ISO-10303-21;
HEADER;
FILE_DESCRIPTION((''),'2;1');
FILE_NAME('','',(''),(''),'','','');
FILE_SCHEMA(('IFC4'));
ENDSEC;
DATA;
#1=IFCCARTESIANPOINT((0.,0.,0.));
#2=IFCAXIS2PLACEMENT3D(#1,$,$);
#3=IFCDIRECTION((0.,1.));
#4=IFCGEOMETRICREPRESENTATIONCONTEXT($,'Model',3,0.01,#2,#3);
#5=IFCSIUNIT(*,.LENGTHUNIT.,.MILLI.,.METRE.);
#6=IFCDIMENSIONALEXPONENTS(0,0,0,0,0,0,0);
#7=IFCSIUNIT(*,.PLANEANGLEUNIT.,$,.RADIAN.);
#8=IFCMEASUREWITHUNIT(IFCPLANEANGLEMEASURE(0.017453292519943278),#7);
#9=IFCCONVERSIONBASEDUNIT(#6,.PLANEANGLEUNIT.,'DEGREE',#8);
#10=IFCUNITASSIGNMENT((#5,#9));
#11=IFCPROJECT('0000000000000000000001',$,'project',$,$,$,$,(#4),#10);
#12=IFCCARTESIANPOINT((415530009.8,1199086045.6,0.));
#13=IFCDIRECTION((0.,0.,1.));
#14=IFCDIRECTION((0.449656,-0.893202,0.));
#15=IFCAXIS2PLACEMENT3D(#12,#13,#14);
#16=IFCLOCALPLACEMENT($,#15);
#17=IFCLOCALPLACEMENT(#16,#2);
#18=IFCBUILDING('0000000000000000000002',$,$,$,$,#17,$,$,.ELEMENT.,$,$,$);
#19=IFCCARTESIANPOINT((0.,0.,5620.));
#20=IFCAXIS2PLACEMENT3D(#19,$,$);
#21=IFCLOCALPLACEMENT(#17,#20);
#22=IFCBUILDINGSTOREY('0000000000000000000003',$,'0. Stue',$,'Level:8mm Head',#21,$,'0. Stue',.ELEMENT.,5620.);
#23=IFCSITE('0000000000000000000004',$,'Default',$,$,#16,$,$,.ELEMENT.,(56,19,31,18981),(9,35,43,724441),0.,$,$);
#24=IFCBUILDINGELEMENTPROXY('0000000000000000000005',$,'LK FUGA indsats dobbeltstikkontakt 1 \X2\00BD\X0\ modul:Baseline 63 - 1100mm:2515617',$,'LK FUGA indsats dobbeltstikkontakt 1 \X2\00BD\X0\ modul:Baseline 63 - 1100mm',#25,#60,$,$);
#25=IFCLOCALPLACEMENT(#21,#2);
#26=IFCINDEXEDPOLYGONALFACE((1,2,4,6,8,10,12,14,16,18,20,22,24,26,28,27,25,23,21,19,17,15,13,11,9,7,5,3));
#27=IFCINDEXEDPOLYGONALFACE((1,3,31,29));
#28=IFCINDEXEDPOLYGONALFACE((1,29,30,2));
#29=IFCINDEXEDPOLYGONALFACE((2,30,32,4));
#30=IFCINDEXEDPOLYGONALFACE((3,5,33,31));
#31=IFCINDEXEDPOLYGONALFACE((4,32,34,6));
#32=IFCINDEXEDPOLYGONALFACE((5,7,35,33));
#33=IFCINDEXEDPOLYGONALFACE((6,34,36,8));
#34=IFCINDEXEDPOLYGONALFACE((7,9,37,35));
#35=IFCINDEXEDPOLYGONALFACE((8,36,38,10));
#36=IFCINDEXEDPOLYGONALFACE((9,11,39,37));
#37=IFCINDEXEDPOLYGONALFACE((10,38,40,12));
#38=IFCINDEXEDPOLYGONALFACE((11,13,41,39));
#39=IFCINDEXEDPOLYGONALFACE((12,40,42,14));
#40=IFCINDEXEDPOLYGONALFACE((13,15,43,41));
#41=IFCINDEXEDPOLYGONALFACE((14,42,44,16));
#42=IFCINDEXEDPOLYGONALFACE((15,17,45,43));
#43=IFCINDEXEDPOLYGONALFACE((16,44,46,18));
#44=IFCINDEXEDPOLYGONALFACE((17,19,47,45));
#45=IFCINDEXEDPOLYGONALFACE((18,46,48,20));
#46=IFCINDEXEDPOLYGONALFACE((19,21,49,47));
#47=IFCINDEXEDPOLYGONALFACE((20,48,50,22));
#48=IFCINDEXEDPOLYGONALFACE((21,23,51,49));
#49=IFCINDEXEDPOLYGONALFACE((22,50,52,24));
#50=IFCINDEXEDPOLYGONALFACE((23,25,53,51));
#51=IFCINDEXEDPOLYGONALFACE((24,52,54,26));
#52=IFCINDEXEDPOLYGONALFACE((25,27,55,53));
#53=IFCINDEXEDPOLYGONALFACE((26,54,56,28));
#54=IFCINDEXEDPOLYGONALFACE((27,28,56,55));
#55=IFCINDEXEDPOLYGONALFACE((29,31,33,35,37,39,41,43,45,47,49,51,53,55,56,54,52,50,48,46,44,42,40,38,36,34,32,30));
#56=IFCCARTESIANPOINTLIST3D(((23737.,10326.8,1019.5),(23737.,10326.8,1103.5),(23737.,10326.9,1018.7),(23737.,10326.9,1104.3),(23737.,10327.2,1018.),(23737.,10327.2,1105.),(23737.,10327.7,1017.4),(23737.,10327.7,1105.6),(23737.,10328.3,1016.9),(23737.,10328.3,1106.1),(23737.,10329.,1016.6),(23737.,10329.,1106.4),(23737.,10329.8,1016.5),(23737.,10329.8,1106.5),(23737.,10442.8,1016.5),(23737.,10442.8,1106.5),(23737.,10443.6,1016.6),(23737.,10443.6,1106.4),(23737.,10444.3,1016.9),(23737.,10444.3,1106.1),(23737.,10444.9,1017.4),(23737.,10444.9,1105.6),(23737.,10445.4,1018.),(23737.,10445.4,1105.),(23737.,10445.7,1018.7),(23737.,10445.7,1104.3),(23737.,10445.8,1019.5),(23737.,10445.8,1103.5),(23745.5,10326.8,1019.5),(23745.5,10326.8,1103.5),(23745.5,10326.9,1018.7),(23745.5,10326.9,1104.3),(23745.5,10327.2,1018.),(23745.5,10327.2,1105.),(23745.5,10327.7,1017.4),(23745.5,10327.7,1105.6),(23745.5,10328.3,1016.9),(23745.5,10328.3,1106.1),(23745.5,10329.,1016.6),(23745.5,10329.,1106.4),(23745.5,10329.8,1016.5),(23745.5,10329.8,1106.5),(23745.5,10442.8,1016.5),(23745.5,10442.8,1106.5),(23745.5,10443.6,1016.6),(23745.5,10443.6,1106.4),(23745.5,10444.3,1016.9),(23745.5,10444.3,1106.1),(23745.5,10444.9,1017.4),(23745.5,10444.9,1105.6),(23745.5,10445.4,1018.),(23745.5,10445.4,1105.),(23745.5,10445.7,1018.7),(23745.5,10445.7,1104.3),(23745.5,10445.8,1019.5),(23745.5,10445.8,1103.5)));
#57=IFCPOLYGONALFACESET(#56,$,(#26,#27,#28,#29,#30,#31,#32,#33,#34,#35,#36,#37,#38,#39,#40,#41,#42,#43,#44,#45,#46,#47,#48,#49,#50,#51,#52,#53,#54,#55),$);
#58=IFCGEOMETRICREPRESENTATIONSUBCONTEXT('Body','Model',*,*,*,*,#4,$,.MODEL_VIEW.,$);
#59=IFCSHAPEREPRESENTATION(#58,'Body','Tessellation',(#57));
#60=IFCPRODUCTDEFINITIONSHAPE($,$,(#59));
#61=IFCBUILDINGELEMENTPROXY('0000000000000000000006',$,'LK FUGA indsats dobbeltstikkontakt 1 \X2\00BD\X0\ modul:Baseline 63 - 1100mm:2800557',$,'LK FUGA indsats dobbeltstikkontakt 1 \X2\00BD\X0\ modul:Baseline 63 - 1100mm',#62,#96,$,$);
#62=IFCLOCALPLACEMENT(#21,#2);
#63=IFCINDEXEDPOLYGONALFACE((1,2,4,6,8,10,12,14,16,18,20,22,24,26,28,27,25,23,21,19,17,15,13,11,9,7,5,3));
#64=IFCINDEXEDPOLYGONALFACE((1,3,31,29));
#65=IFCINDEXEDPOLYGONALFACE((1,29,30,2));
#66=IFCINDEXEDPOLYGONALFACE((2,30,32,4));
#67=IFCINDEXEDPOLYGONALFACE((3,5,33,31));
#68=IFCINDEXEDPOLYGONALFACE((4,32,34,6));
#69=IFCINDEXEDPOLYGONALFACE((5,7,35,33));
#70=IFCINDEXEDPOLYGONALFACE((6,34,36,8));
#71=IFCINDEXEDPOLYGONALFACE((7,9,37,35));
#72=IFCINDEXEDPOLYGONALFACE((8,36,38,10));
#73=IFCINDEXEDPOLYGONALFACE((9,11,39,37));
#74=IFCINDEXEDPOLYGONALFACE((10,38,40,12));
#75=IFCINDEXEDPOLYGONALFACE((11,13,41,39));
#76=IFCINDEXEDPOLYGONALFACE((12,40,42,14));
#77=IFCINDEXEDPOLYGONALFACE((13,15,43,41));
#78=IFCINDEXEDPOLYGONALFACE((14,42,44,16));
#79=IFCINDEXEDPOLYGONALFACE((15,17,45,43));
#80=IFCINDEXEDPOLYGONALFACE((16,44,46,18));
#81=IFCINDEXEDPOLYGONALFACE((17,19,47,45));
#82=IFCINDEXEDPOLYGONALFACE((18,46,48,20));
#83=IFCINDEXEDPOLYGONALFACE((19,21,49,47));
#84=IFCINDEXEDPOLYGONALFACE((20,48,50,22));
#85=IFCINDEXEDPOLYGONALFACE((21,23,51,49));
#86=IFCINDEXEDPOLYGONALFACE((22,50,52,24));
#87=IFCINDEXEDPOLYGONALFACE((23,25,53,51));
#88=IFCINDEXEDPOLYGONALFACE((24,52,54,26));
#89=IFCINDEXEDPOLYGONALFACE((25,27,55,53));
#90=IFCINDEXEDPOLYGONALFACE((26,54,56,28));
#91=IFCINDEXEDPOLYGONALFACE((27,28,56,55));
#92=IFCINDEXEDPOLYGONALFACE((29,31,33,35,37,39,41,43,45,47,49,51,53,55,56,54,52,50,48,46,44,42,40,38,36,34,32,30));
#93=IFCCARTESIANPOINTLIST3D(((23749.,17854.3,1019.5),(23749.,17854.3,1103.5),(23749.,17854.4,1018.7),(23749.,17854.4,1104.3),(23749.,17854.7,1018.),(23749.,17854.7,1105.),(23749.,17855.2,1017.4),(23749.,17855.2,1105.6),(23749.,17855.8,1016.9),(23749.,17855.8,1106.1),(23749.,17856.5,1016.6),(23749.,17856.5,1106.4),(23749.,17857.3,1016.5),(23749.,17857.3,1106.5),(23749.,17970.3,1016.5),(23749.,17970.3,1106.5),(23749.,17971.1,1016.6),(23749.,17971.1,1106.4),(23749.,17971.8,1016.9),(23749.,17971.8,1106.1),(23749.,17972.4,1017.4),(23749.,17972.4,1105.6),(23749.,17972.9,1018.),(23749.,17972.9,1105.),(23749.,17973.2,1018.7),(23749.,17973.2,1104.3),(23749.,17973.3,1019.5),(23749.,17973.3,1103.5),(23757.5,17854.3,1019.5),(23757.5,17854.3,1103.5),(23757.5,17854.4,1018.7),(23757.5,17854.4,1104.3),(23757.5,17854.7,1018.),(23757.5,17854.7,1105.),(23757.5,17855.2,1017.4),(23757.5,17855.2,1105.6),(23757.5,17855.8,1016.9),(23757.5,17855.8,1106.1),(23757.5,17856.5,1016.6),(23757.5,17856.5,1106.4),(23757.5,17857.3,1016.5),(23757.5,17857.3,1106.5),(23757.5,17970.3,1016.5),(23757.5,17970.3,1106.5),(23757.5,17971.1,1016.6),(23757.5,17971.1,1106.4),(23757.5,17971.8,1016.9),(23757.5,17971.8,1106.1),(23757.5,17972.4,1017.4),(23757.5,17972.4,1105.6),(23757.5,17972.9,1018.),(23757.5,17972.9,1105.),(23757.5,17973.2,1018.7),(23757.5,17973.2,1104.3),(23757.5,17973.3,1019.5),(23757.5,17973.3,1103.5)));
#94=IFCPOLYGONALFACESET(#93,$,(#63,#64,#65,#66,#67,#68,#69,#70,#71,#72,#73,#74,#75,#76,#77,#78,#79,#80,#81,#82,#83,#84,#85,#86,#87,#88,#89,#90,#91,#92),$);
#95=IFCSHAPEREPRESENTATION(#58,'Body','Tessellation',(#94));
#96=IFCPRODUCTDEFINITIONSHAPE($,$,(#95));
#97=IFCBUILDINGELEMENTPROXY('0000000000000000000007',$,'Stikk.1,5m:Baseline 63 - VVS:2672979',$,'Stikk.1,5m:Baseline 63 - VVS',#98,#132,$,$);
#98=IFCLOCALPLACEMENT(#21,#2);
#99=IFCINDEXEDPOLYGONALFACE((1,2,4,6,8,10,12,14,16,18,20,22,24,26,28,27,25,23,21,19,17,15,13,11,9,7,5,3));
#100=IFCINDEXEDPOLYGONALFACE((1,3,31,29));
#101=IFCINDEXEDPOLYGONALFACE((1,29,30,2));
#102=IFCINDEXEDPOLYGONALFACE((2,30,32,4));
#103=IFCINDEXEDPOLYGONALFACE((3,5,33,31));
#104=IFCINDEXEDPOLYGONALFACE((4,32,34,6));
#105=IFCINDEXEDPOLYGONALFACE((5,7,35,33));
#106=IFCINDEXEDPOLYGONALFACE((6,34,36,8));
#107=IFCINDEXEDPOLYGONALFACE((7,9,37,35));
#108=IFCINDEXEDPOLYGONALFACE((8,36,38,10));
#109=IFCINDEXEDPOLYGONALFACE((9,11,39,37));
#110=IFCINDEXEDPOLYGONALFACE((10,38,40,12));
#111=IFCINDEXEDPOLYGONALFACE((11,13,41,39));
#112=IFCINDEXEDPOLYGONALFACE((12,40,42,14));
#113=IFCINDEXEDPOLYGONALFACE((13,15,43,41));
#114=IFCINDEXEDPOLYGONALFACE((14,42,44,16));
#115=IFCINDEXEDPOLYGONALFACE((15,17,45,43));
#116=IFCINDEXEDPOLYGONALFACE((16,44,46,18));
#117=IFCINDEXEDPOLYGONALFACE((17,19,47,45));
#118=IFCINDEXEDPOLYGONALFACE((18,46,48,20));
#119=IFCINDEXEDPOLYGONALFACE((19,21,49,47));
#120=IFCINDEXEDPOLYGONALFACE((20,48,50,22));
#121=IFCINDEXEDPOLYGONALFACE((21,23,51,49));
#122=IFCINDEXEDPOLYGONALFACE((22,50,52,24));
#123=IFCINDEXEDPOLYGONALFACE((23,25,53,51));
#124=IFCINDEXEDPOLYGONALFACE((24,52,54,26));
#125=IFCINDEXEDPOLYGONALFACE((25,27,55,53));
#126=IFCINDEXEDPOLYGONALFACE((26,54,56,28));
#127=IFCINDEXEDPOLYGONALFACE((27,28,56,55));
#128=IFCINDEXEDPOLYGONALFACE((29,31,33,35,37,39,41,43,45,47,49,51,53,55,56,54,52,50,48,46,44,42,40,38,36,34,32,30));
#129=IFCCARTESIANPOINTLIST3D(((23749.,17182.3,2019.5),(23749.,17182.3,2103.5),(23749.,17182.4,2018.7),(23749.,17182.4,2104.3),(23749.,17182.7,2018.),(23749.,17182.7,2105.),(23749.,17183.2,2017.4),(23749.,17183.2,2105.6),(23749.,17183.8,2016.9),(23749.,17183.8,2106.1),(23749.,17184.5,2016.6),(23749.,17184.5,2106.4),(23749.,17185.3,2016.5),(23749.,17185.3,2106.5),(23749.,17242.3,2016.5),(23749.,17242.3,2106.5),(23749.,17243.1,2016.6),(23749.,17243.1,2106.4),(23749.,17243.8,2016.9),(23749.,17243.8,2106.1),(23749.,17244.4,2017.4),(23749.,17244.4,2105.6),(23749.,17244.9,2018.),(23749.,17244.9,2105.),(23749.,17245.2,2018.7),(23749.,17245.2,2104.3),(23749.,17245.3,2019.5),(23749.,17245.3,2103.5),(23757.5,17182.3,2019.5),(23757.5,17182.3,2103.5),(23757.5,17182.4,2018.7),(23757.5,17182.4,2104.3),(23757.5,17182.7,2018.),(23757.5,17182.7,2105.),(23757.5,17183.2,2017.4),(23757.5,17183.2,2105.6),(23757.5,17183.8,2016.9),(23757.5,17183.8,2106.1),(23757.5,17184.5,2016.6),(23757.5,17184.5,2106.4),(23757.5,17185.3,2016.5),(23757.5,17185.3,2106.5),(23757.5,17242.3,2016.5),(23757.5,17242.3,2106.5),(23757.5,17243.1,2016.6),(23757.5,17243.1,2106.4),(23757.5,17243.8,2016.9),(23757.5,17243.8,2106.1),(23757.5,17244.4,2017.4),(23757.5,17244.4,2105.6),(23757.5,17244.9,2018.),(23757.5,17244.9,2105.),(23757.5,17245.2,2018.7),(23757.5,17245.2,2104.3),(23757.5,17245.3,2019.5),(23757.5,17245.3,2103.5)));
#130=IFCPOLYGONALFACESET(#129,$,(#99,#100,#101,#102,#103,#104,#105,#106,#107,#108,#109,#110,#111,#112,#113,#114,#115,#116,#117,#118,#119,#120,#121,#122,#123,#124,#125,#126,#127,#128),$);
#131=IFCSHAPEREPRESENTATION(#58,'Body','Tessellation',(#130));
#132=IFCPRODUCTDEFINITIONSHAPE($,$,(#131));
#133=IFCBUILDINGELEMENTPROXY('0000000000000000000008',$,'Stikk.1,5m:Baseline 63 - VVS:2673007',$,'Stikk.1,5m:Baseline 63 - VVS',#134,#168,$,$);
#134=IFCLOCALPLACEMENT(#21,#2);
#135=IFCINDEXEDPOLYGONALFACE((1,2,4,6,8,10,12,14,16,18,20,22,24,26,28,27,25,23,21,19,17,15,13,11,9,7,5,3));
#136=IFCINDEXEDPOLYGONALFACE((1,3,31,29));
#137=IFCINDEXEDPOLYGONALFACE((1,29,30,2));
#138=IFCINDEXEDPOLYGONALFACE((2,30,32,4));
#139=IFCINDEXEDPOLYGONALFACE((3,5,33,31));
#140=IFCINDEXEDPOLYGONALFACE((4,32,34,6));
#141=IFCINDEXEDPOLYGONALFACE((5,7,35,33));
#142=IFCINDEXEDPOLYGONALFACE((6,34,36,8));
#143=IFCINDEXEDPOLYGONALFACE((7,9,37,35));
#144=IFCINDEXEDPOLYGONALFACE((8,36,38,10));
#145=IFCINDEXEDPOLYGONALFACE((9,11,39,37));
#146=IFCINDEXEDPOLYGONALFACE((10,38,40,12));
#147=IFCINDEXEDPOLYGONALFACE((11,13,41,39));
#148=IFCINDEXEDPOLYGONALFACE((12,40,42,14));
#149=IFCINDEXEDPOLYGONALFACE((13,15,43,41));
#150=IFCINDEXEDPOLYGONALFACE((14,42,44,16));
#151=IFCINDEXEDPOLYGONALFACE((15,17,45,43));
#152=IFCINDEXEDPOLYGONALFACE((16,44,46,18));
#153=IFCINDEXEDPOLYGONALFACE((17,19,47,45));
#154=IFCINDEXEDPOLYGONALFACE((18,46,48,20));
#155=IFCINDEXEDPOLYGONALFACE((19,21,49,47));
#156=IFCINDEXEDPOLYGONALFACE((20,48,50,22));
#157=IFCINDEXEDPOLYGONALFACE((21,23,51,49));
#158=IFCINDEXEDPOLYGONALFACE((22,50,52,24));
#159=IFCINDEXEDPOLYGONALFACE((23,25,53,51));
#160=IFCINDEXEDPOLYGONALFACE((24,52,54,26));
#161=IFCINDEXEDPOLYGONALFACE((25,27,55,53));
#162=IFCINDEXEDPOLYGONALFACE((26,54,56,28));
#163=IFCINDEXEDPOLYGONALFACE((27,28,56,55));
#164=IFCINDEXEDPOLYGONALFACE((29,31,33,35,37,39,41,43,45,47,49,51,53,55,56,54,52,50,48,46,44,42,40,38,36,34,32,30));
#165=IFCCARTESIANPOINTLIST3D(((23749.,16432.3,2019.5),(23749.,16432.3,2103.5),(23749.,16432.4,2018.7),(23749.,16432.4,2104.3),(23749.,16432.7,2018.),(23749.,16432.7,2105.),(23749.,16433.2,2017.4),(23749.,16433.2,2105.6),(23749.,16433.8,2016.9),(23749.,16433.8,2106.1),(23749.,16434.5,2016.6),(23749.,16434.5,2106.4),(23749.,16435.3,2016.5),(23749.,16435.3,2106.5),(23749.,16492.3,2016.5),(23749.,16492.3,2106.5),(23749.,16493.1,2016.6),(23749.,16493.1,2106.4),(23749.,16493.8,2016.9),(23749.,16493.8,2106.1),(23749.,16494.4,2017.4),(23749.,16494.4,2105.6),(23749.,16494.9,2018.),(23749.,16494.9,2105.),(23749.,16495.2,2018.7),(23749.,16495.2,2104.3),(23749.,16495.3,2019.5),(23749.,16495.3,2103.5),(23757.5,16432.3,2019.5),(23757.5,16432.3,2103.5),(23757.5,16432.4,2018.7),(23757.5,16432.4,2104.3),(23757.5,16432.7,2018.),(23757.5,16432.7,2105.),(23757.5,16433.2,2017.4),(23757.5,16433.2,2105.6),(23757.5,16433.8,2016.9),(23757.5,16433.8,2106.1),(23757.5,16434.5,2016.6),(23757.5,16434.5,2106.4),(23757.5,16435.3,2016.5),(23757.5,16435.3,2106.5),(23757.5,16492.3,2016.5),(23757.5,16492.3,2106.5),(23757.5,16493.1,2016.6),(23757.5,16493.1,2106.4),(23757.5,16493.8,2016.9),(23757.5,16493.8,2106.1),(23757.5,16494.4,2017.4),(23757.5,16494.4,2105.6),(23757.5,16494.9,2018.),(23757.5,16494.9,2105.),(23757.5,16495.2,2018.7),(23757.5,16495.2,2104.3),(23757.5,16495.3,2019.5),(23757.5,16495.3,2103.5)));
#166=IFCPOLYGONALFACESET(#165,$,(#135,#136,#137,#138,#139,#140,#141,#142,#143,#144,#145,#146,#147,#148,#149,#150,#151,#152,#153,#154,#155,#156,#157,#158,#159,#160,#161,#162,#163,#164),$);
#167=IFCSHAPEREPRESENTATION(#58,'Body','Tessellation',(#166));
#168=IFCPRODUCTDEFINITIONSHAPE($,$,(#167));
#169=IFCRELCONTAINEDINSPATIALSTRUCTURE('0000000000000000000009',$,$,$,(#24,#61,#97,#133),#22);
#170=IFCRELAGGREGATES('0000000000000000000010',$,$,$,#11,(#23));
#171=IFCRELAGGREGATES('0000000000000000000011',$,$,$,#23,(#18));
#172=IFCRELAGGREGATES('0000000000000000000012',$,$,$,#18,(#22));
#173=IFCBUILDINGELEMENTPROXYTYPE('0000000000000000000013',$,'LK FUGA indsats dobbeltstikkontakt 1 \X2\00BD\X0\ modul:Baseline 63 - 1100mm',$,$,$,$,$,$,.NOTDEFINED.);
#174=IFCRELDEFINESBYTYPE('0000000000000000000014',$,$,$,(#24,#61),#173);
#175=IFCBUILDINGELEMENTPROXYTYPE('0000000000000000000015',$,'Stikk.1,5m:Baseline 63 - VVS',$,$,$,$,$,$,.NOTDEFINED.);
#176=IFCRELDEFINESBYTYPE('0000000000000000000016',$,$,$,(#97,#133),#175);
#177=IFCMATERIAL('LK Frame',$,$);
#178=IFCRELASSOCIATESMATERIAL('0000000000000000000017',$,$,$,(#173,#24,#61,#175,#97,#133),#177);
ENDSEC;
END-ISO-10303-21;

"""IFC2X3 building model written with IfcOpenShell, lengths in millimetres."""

from ifc_helpers import new_model, entity, si_unit, converted_unit, direction, frame, frame_2d, origin, place, context, subcontext, project, spatial, polyline, circle_curve, parameter, trimmed, segment, composite_curve, outline, extrude, source, transform, mapped, material, type_object, type_shapes, element, save


model = new_model("IFC2X3")

# Units and contexts
model_context = context("Model", 3, precision=0.01, world=origin(), true_north=direction((0.0, 1.0)))
body_context = subcontext(model_context, "Body", "Model", "MODEL_VIEW")
ifc_project = project(units=[si_unit("LENGTHUNIT", "METRE", prefix="MILLI"), converted_unit("PLANEANGLEUNIT", "DEGREE", entity("IfcPlaneAngleMeasure", 0.017453292519943278), si_unit("PLANEANGLEUNIT", "RADIAN"), dimensions=[0, 0, 0, 0, 0, 0, 0])], contexts=[model_context])

# Site, building, storey
site_placement = place(None, frame((415530009.8, 1199086045.6, 0.0), z_axis=(0.0, 0.0, 1.0), x_axis=(0.449656, -0.893202, 0.0)))
site = spatial("IfcSite", under=ifc_project, at=site_placement, Name="Default", CompositionType="ELEMENT", RefLatitude=(56, 19, 31, 18981), RefLongitude=(9, 35, 43, 724441), RefElevation=0.0)
building_placement = place(site_placement, origin())
building = spatial("IfcBuilding", under=site, at=building_placement, CompositionType="ELEMENT")
storey_placement = place(building_placement, frame((0.0, 0.0, 5620.0)))
storey = spatial("IfcBuildingStorey", under=building, at=storey_placement, Name="0. Stue", ObjectType="Level:8mm Head", LongName="0. Stue", CompositionType="ELEMENT", Elevation=5620.0)

# Building element proxies
ifc_material_1 = material(Name="LK Frame")
building_element_proxy_type_1 = type_object("IfcBuildingElementProxyType", Name="LK FUGA indsats dobbeltstikkontakt 1 ½ modul:Baseline 63 - 1100mm", PredefinedType="NOTDEFINED", material=ifc_material_1)
shared_shape_1 = source(origin(), body_context, "Body", "SweptSolid", [
    extrude(outline(composite_curve([segment(polyline([(-42.0, -59.5), (42.0, -59.5)]), True, "CONTINUOUS"), segment(trimmed(circle_curve(frame_2d((42.0, -56.5), x_axis=(-1.0, 0.0)), 3.0), [parameter(90.0)], [parameter(180.0)], True, "PARAMETER"), True, "CONTINUOUS"), segment(polyline([(45.0, -56.5), (45.0, 56.5)]), True, "CONTINUOUS"), segment(trimmed(circle_curve(frame_2d((42.0, 56.5), x_axis=(-1.0, 0.0)), 3.0), [parameter(180.0)], [parameter(270.0)], True, "PARAMETER"), True, "CONTINUOUS"), segment(polyline([(42.0, 59.5), (-42.0, 59.5)]), True, "CONTINUOUS"), segment(trimmed(circle_curve(frame_2d((-42.0, 56.5), x_axis=(1.0, 0.0)), 3.0), [parameter(90.0)], [parameter(180.0)], True, "PARAMETER"), True, "CONTINUOUS"), segment(polyline([(-45.0, 56.5), (-45.0, -56.5)]), True, "CONTINUOUS"), segment(trimmed(circle_curve(frame_2d((-42.0, -56.5), x_axis=(1.0, 0.0)), 3.0), [parameter(180.0)], [parameter(270.0)], True, "PARAMETER"), True, "CONTINUOUS")], self_intersect=False)), frame((0.0, -38.5, 0.0), z_axis=(0.0, 0.0, 1.0), x_axis=(0.0, 1.0, 0.0)), (0.0, 0.0, 1.0), 8.5),
])
type_shapes(building_element_proxy_type_1, [shared_shape_1])
for number, where, z_axis, x_axis, name in (
    (1, (23737.0, 10386.3, 1100.0), (1.0, 0.0, 0.0), (0.0, 1.0, 0.0), "LK FUGA indsats dobbeltstikkontakt 1 ½ modul:Baseline 63 - 1100mm:2515617"),
    (2, (23749.0, 17913.8, 1100.0), (1.0, 0.0, 0.0), (0.0, 1.0, 0.0), "LK FUGA indsats dobbeltstikkontakt 1 ½ modul:Baseline 63 - 1100mm:2800557"),
):
    element("IfcBuildingElementProxy", number, at=place(storey_placement, frame(where, z_axis=z_axis, x_axis=x_axis)), inside=storey, type_object=building_element_proxy_type_1, material=ifc_material_1, Name=name, ObjectType="LK FUGA indsats dobbeltstikkontakt 1 ½ modul:Baseline 63 - 1100mm", context=body_context, shape_type="MappedRepresentation", body=[
        mapped(shared_shape_1, transform((0.0, 0.0, 0.0), scale=1.0)),
    ])
building_element_proxy_type_2 = type_object("IfcBuildingElementProxyType", Name="Stikk.1,5m:Baseline 63 - VVS", PredefinedType="NOTDEFINED", material=ifc_material_1)
shared_shape_2 = source(origin(), body_context, "Body", "SweptSolid", [
    extrude(outline(composite_curve([segment(polyline([(-42.0, -31.5), (42.0, -31.5)]), True, "CONTINUOUS"), segment(trimmed(circle_curve(frame_2d((42.0, -28.5), x_axis=(-1.0, 0.0)), 3.0), [parameter(90.0)], [parameter(180.0)], True, "PARAMETER"), True, "CONTINUOUS"), segment(polyline([(45.0, -28.5), (45.0, 28.5)]), True, "CONTINUOUS"), segment(trimmed(circle_curve(frame_2d((42.0, 28.5), x_axis=(-1.0, 0.0)), 3.0), [parameter(180.0)], [parameter(270.0)], True, "PARAMETER"), True, "CONTINUOUS"), segment(polyline([(42.0, 31.5), (-42.0, 31.5)]), True, "CONTINUOUS"), segment(trimmed(circle_curve(frame_2d((-42.0, 28.5), x_axis=(1.0, 0.0)), 3.0), [parameter(90.0)], [parameter(180.0)], True, "PARAMETER"), True, "CONTINUOUS"), segment(polyline([(-45.0, 28.5), (-45.0, -28.5)]), True, "CONTINUOUS"), segment(trimmed(circle_curve(frame_2d((-42.0, -28.5), x_axis=(1.0, 0.0)), 3.0), [parameter(180.0)], [parameter(270.0)], True, "PARAMETER"), True, "CONTINUOUS")], self_intersect=False)), frame((0.0, -38.5, 0.0), z_axis=(0.0, 0.0, 1.0), x_axis=(0.0, 1.0, 0.0)), (0.0, 0.0, 1.0), 8.5),
])
type_shapes(building_element_proxy_type_2, [shared_shape_2])
for number, where, z_axis, x_axis, name in (
    (3, (23749.0, 17213.8, 2100.0), (1.0, 0.0, 0.0), (0.0, 1.0, 0.0), "Stikk.1,5m:Baseline 63 - VVS:2672979"),
    (4, (23749.0, 16463.8, 2100.0), (1.0, 0.0, 0.0), (0.0, 1.0, 0.0), "Stikk.1,5m:Baseline 63 - VVS:2673007"),
):
    element("IfcBuildingElementProxy", number, at=place(storey_placement, frame(where, z_axis=z_axis, x_axis=x_axis)), inside=storey, type_object=building_element_proxy_type_2, material=ifc_material_1, Name=name, ObjectType="Stikk.1,5m:Baseline 63 - VVS", context=body_context, shape_type="MappedRepresentation", body=[
        mapped(shared_shape_2, transform((0.0, 0.0, 0.0), scale=1.0)),
    ])

save(model, "model.ifc")
